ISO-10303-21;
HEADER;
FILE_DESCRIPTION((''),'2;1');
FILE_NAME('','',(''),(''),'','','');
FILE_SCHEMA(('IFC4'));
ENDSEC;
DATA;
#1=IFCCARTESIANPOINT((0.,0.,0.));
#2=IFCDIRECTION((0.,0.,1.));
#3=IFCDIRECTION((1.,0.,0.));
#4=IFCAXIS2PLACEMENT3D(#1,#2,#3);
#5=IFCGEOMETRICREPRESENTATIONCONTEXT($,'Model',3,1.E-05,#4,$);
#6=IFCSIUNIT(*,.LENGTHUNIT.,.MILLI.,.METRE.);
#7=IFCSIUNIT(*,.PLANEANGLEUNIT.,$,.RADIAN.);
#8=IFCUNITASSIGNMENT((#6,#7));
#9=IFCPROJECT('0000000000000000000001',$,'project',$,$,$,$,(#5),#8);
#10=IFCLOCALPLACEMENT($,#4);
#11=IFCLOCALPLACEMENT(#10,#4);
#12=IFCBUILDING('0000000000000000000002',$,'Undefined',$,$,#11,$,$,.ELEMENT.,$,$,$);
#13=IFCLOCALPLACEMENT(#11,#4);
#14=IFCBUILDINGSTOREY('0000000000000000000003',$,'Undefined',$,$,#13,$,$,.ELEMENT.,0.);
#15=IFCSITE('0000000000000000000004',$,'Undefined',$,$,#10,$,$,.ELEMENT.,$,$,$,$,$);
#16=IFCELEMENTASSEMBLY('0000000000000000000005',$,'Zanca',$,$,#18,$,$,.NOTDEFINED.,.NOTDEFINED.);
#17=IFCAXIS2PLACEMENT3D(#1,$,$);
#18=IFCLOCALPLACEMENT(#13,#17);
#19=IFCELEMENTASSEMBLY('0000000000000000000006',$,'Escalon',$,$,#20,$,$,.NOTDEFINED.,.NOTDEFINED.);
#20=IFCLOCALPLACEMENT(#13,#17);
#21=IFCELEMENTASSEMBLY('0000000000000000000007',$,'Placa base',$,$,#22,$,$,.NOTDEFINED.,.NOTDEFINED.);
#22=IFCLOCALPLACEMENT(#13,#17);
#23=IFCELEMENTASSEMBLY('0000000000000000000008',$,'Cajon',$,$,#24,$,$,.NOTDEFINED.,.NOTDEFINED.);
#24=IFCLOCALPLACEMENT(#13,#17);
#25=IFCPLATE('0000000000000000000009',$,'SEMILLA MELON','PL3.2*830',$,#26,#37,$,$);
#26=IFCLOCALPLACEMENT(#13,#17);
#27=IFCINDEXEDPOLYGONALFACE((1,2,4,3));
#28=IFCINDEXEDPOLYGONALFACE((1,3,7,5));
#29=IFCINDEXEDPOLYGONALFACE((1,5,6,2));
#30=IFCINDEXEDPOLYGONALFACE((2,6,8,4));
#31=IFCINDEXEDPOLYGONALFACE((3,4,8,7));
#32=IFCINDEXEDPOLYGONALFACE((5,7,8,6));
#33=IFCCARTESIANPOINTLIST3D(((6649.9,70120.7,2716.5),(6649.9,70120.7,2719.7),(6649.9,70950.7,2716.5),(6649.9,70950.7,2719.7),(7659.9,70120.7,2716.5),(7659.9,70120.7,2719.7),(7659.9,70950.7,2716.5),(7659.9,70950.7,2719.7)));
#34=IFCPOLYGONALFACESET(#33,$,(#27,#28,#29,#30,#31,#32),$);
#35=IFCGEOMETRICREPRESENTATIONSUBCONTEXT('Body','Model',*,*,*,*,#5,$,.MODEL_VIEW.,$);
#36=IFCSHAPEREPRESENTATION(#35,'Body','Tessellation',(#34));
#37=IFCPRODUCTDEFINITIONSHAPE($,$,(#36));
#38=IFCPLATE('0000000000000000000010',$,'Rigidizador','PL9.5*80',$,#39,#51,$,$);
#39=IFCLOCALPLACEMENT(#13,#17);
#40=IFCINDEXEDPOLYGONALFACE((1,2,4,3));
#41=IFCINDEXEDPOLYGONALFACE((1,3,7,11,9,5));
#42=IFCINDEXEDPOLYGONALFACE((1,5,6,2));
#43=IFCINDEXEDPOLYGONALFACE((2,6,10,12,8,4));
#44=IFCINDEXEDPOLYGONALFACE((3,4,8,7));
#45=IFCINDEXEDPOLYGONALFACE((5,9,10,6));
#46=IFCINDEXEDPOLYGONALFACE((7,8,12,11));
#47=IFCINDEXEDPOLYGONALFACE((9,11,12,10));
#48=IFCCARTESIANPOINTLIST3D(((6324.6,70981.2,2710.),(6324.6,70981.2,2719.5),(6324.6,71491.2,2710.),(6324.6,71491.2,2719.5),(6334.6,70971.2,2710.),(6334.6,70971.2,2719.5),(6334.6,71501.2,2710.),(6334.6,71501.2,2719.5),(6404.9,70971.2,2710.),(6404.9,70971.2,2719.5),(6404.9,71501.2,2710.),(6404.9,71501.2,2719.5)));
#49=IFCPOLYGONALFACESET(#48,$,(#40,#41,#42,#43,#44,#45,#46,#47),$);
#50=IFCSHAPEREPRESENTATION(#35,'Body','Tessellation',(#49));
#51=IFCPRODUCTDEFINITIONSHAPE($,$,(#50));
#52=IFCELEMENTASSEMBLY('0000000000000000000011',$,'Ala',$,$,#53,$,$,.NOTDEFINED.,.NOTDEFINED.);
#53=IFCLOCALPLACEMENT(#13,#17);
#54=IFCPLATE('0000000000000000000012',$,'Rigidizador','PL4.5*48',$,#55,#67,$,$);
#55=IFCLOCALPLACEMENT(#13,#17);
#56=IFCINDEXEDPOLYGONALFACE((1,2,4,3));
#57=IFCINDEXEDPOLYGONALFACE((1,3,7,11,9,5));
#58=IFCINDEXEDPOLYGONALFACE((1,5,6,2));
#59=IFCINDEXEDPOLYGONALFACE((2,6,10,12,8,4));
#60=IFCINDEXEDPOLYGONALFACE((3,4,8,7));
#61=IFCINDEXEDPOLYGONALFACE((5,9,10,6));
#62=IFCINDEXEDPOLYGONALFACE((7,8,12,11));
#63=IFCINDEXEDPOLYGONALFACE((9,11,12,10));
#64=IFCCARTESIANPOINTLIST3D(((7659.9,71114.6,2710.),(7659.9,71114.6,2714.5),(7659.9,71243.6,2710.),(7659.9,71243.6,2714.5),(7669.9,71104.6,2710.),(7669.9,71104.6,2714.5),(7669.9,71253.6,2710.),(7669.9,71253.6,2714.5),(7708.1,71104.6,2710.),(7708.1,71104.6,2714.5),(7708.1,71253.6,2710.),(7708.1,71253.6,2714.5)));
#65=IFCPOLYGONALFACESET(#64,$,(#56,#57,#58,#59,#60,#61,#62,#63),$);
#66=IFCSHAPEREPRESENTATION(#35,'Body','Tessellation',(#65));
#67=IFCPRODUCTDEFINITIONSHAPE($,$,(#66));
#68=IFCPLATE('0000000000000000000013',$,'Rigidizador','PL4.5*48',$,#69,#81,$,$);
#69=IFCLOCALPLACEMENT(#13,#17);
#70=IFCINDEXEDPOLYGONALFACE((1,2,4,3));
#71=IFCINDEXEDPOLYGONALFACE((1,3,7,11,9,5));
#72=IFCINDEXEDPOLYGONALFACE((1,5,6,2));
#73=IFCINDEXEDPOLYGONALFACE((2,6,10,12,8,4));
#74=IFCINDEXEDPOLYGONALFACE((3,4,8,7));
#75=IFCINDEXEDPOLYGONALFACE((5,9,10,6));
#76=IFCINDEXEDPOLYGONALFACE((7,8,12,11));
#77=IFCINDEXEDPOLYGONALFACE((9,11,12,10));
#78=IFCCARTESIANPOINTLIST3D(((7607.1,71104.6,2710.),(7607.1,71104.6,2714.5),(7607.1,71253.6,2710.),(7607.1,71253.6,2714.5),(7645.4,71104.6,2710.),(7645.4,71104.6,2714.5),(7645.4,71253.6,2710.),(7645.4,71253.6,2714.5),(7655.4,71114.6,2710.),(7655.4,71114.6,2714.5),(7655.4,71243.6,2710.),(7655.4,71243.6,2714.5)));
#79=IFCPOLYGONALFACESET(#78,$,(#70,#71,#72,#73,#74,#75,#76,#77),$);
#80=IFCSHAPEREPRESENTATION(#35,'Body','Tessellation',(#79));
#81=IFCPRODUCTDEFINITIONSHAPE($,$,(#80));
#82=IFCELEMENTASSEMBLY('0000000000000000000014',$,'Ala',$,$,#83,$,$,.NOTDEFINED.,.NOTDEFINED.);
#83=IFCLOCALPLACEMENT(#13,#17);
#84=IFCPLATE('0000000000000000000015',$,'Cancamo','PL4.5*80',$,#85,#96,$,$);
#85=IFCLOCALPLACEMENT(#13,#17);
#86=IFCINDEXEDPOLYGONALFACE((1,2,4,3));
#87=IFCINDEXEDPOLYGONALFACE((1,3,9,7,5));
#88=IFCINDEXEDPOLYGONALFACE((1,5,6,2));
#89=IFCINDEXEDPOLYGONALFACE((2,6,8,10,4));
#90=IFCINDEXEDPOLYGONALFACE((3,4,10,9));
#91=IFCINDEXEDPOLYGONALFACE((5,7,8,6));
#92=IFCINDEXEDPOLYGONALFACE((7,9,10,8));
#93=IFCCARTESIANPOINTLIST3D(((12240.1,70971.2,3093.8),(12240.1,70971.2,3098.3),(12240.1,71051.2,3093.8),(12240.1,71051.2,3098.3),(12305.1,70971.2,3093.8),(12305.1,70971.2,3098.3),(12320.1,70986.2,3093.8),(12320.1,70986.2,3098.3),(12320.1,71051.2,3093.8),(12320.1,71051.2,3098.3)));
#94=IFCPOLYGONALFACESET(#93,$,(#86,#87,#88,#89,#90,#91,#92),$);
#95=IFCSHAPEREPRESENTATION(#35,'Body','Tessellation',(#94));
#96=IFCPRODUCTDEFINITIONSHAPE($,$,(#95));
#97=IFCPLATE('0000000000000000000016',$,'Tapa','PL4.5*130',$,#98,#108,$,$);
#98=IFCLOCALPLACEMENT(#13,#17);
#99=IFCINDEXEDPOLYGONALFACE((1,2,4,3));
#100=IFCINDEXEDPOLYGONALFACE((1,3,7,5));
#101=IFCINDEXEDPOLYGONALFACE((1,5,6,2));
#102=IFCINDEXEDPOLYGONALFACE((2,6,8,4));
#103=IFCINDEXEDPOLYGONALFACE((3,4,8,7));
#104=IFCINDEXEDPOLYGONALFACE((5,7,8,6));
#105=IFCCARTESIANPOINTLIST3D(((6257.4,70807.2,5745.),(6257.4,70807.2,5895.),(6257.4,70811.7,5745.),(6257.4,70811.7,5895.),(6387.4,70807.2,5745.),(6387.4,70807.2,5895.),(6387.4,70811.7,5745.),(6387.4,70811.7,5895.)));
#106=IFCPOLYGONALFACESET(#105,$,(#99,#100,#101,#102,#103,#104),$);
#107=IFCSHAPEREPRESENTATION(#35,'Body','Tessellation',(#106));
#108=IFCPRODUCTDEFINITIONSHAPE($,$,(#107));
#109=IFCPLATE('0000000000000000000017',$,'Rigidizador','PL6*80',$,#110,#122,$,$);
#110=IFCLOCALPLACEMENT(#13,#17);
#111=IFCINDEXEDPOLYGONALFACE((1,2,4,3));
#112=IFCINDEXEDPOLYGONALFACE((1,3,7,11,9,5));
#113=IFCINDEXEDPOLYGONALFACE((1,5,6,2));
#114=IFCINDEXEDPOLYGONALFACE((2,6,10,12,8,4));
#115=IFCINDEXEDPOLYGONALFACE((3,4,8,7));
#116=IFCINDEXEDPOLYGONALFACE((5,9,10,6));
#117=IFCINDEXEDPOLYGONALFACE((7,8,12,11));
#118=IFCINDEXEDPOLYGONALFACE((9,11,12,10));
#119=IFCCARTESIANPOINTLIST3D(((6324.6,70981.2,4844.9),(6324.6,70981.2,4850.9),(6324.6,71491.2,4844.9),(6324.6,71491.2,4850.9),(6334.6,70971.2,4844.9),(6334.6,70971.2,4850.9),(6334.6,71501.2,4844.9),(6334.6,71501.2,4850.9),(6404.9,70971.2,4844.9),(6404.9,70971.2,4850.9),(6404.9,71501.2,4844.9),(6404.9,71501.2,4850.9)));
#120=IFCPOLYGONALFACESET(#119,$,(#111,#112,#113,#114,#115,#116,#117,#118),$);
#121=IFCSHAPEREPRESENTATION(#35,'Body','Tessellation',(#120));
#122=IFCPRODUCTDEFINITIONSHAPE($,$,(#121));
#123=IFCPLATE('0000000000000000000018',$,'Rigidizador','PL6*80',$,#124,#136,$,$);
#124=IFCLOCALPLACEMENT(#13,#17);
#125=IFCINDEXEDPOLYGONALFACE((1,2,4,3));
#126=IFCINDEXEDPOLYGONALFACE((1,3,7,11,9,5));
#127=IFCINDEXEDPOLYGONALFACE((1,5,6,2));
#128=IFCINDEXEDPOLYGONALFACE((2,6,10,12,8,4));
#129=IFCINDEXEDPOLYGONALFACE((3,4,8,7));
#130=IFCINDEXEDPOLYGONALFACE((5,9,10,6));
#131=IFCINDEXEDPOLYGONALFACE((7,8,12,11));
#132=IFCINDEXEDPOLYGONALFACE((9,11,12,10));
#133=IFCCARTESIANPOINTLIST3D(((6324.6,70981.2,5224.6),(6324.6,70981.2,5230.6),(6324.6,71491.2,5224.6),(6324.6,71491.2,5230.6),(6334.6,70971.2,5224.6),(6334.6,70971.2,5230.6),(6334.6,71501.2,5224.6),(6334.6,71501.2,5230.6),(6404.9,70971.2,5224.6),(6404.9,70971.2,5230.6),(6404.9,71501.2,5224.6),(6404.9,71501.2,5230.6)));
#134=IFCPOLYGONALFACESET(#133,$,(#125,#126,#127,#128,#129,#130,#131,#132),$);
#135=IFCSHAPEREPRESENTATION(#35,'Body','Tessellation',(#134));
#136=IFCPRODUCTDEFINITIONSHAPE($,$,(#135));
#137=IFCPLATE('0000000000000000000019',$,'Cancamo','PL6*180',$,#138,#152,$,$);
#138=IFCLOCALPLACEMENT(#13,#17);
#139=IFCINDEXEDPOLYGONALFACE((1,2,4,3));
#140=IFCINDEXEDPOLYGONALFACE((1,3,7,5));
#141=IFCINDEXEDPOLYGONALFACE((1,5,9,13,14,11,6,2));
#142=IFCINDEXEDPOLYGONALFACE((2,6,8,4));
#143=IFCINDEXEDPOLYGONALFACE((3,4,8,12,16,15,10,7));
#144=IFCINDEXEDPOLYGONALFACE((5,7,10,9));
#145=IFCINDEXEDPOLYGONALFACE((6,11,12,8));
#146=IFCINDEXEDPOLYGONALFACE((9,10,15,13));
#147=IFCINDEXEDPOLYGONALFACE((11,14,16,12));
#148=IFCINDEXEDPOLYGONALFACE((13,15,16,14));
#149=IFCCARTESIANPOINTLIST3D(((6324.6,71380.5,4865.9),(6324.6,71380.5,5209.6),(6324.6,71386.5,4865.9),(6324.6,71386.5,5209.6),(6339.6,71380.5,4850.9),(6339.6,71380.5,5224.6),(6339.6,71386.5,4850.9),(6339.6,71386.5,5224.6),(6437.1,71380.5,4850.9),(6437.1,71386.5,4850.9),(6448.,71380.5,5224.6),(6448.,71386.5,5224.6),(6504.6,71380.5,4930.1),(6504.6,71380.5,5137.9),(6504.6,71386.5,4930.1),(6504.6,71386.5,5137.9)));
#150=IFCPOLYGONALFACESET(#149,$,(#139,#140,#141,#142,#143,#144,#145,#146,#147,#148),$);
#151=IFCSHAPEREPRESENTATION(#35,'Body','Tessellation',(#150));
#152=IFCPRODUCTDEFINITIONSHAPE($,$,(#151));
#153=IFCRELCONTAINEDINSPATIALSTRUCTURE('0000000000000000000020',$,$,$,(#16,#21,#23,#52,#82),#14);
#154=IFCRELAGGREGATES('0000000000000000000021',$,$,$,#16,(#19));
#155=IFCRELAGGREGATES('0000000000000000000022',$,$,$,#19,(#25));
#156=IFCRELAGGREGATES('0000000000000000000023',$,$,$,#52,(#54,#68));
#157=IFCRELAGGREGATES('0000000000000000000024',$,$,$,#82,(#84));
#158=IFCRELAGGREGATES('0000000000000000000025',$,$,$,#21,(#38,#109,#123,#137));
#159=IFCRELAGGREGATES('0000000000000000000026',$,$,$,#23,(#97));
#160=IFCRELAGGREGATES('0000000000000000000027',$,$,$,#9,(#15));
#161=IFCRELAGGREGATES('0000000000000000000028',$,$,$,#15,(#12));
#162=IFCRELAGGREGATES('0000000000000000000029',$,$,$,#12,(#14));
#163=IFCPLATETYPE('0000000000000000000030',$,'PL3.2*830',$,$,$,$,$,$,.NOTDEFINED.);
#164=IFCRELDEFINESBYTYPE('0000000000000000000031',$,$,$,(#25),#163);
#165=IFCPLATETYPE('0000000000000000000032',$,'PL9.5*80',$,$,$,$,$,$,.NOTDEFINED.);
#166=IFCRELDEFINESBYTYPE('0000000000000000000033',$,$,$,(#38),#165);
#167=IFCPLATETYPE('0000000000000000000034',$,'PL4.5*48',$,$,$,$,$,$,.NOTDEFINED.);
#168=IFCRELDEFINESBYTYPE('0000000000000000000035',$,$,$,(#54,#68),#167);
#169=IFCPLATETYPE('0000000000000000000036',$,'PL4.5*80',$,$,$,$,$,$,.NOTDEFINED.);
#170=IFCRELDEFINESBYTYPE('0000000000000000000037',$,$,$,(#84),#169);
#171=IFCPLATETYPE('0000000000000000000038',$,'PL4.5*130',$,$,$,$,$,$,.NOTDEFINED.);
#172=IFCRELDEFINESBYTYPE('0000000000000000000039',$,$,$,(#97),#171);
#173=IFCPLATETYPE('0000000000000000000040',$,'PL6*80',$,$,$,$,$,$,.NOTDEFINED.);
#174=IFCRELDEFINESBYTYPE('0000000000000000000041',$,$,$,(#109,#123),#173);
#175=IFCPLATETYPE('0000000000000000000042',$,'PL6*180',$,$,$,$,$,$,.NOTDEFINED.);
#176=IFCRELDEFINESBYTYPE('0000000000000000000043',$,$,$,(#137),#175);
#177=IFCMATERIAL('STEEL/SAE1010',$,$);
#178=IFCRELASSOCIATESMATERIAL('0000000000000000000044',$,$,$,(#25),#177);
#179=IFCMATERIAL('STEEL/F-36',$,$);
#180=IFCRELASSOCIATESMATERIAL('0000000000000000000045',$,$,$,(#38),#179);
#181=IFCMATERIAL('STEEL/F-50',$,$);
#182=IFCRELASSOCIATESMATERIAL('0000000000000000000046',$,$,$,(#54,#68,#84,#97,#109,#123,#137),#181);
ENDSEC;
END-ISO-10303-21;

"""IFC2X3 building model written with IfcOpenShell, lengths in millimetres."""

from ifc_helpers import new_model, si_unit, frame, origin_with_axes, place, context, subcontext, project, spatial, polyline, outline, extrude, material, type_object, element, aggregate, save


model = new_model("IFC2X3")

# Units and contexts
model_context = context("Model", 3, precision=1e-05, world=origin_with_axes())
body_context = subcontext(model_context, "Body", "Model", "MODEL_VIEW")
ifc_project = project(units=[si_unit("LENGTHUNIT", "METRE", prefix="MILLI"), si_unit("PLANEANGLEUNIT", "RADIAN")], contexts=[model_context])

# Site, building, storey
site_placement = place(None, origin_with_axes())
site = spatial("IfcSite", under=ifc_project, at=site_placement, Name="Undefined", CompositionType="ELEMENT")
building_placement = place(site_placement, origin_with_axes())
building = spatial("IfcBuilding", under=site, at=building_placement, Name="Undefined", CompositionType="ELEMENT")
storey_placement = place(building_placement, origin_with_axes())
storey = spatial("IfcBuildingStorey", under=building, at=storey_placement, Name="Undefined", CompositionType="ELEMENT", Elevation=0.0)

# Element assemblies
assembly_1_placement = place(storey_placement, origin_with_axes())
assembly_1 = element("IfcElementAssembly", 1, at=assembly_1_placement, inside=storey, Name="Zanca", AssemblyPlace="NOTDEFINED", PredefinedType="NOTDEFINED")
assembly_2_placement = place(assembly_1_placement, origin_with_axes())
assembly_2 = element("IfcElementAssembly", 2, at=assembly_2_placement, Name="Escalon", AssemblyPlace="NOTDEFINED", PredefinedType="NOTDEFINED")
aggregate(assembly_1, [assembly_2])
ifc_material_1 = material(Name="STEEL/F-36")

# Shared definitions
ifc_material_2 = material(Name="STEEL/SAE1010")

# Element assemblies
assembly_3_placement = place(storey_placement, origin_with_axes())
assembly_3 = element("IfcElementAssembly", 3, at=assembly_3_placement, inside=storey, Name="Placa base", AssemblyPlace="NOTDEFINED", PredefinedType="NOTDEFINED")
ifc_material_3 = material(Name="STEEL/F-50")
assembly_4_placement = place(storey_placement, origin_with_axes())
assembly_4 = element("IfcElementAssembly", 4, at=assembly_4_placement, inside=storey, Name="Cajon", AssemblyPlace="NOTDEFINED", PredefinedType="NOTDEFINED")

# Plates
plate_type_1 = type_object("IfcPlateType", Name="PL3.2*830", PredefinedType="NOTDEFINED")
plate_1_placement = place(assembly_2_placement, frame((6649.9, 70950.7, 2718.1), z_axis=(0.0, 0.0, 1.0), x_axis=(0.0, -1.0, 0.0)))
plate_1 = element("IfcPlate", 5, at=plate_1_placement, type_object=plate_type_1, material=ifc_material_2, Name="SEMILLA MELON", Description="PL3.2*830", context=body_context, shape_type="SweptSolid", body=[
    extrude(outline(polyline([(0.0, 0.0), (830.0, 0.0), (830.0, 1010.0), (0.0, 1010.0), (0.0, 0.0)])), frame((0.0, 0.0, -1.6), z_axis=(0.0, 0.0, 1.0), x_axis=(1.0, 0.0, 0.0)), (0.0, 0.0, 1.0), 3.2),
])
aggregate(assembly_2, [plate_1])
plate_type_2 = type_object("IfcPlateType", Name="PL9.5*80", PredefinedType="NOTDEFINED")
plate_2_placement = place(assembly_3_placement, frame((6324.6, 71501.2, 2714.7), z_axis=(0.0, 0.0, -1.0), x_axis=(1.0, 0.0, 0.0)))
plate_2 = element("IfcPlate", 6, at=plate_2_placement, type_object=plate_type_2, material=ifc_material_1, Name="Rigidizador", Description="PL9.5*80", context=body_context, shape_type="SweptSolid", body=[
    extrude(outline(polyline([(0.0, 10.0), (10.0, 0.0), (80.2, 0.0), (80.2, 530.0), (10.0, 530.0), (0.0, 520.0), (0.0, 10.0)])), frame((0.0, 0.0, -4.8), z_axis=(0.0, 0.0, 1.0), x_axis=(1.0, 0.0, 0.0)), (0.0, 0.0, 1.0), 9.5),
])

# Element assembly, plates
assembly_5_placement = place(storey_placement, origin_with_axes())
assembly_5 = element("IfcElementAssembly", 7, at=assembly_5_placement, inside=storey, Name="Ala", AssemblyPlace="NOTDEFINED", PredefinedType="NOTDEFINED")
plate_type_3 = type_object("IfcPlateType", Name="PL4.5*48", PredefinedType="NOTDEFINED")
plate_3_placement = place(assembly_5_placement, frame((7659.9, 71104.6, 2712.2), z_axis=(0.0, 0.0, 1.0), x_axis=(1.0, 0.0, 0.0)))
plate_3 = element("IfcPlate", 8, at=plate_3_placement, type_object=plate_type_3, material=ifc_material_3, Name="Rigidizador", Description="PL4.5*48", context=body_context, shape_type="SweptSolid", body=[
    extrude(outline(polyline([(0.0, 10.0), (10.0, 0.0), (48.3, 0.0), (48.3, 149.0), (10.0, 149.0), (0.0, 139.0), (0.0, 10.0)])), frame((0.0, 0.0, -2.2), z_axis=(0.0, 0.0, 1.0), x_axis=(1.0, 0.0, 0.0)), (0.0, 0.0, 1.0), 4.5),
])
plate_4_placement = place(assembly_5_placement, frame((7655.4, 71104.6, 2712.2), z_axis=(0.0, 0.0, -1.0), x_axis=(-1.0, 0.0, 0.0)))
plate_4 = element("IfcPlate", 9, at=plate_4_placement, type_object=plate_type_3, material=ifc_material_3, Name="Rigidizador", Description="PL4.5*48", context=body_context, shape_type="SweptSolid", body=[
    extrude(outline(polyline([(0.0, 10.0), (10.0, 0.0), (48.3, 0.0), (48.3, 149.0), (10.0, 149.0), (0.0, 139.0), (0.0, 10.0)])), frame((0.0, 0.0, -2.2), z_axis=(0.0, 0.0, 1.0), x_axis=(1.0, 0.0, 0.0)), (0.0, 0.0, 1.0), 4.5),
])
aggregate(assembly_5, [plate_3, plate_4])

# Element assembly, plate
assembly_6_placement = place(storey_placement, origin_with_axes())
assembly_6 = element("IfcElementAssembly", 10, at=assembly_6_placement, inside=storey, Name="Ala", AssemblyPlace="NOTDEFINED", PredefinedType="NOTDEFINED")
plate_type_4 = type_object("IfcPlateType", Name="PL4.5*80", PredefinedType="NOTDEFINED")
plate_5_placement = place(assembly_6_placement, frame((12240.1, 70971.2, 3096.1), z_axis=(0.0, 0.000023, 1.0), x_axis=(1.0, 0.0, 0.0)))
plate_5 = element("IfcPlate", 11, at=plate_5_placement, type_object=plate_type_4, material=ifc_material_3, Name="Cancamo", Description="PL4.5*80", context=body_context, shape_type="SweptSolid", body=[
    extrude(outline(polyline([(0.0, 0.0), (65.0, 0.0), (80.0, 15.0), (80.0, 80.0), (0.0, 80.0), (0.0, 0.0)])), frame((0.0, 0.0, -2.2), z_axis=(0.0, 0.0, 1.0), x_axis=(1.0, 0.0, 0.0)), (0.0, 0.0, 1.0), 4.5),
])
aggregate(assembly_6, [plate_5])

# Plates
plate_type_5 = type_object("IfcPlateType", Name="PL4.5*130", PredefinedType="NOTDEFINED")
plate_6_placement = place(assembly_4_placement, frame((6387.4, 70809.4, 5895.0), z_axis=(0.0, -1.0, 0.0), x_axis=(-1.0, 0.0, 0.0)))
plate_6 = element("IfcPlate", 12, at=plate_6_placement, type_object=plate_type_5, material=ifc_material_3, Name="Tapa", Description="PL4.5*130", context=body_context, shape_type="SweptSolid", body=[
    extrude(outline(polyline([(0.0, 0.0), (130.0, 0.0), (130.0, 150.0), (0.0, 150.0), (0.0, 0.0)])), frame((0.0, 0.0, -2.2), z_axis=(0.0, 0.0, 1.0), x_axis=(1.0, 0.0, 0.0)), (0.0, 0.0, 1.0), 4.5),
])
plate_type_6 = type_object("IfcPlateType", Name="PL6*80", PredefinedType="NOTDEFINED")
plate_7_placement = place(assembly_3_placement, frame((6324.6, 71501.2, 4847.9), z_axis=(0.0, 0.0, -1.0), x_axis=(1.0, 0.0, 0.0)))
plate_7 = element("IfcPlate", 13, at=plate_7_placement, type_object=plate_type_6, material=ifc_material_3, Name="Rigidizador", Description="PL6*80", context=body_context, shape_type="SweptSolid", body=[
    extrude(outline(polyline([(0.0, 10.0), (10.0, 0.0), (80.2, 0.0), (80.2, 530.0), (10.0, 530.0), (0.0, 520.0), (0.0, 10.0)])), frame((0.0, 0.0, -3.0), z_axis=(0.0, 0.0, 1.0), x_axis=(1.0, 0.0, 0.0)), (0.0, 0.0, 1.0), 6.0),
])
plate_8_placement = place(assembly_3_placement, frame((6324.6, 71501.2, 5227.6), z_axis=(0.0, 0.0, -1.0), x_axis=(1.0, 0.0, 0.0)))
plate_8 = element("IfcPlate", 14, at=plate_8_placement, type_object=plate_type_6, material=ifc_material_3, Name="Rigidizador", Description="PL6*80", context=body_context, shape_type="SweptSolid", body=[
    extrude(outline(polyline([(0.0, 10.0), (10.0, 0.0), (80.2, 0.0), (80.2, 530.0), (10.0, 530.0), (0.0, 520.0), (0.0, 10.0)])), frame((0.0, 0.0, -3.0), z_axis=(0.0, 0.0, 1.0), x_axis=(1.0, 0.0, 0.0)), (0.0, 0.0, 1.0), 6.0),
])
plate_type_7 = type_object("IfcPlateType", Name="PL6*180", PredefinedType="NOTDEFINED")
plate_9_placement = place(assembly_3_placement, frame((6324.6, 71383.5, 4850.9), z_axis=(0.0, 1.0, 0.0), x_axis=(0.0, 0.0, 1.0)))
plate_9 = element("IfcPlate", 15, at=plate_9_placement, type_object=plate_type_7, material=ifc_material_3, Name="Cancamo", Description="PL6*180", context=body_context, shape_type="SweptSolid", body=[
    extrude(outline(polyline([(0.0, 15.0), (15.0, 0.0), (358.7, 0.0), (373.7, 15.0), (373.7, 123.4), (287.0, 180.0), (79.2, 180.0), (0.0, 112.4), (0.0, 15.0)])), frame((0.0, 0.0, -3.0), z_axis=(0.0, 0.0, 1.0), x_axis=(1.0, 0.0, 0.0)), (0.0, 0.0, 1.0), 6.0),
])
aggregate(assembly_3, [plate_2, plate_7, plate_8, plate_9])

aggregate(assembly_4, [plate_6])

save(model, "model.ifc")
